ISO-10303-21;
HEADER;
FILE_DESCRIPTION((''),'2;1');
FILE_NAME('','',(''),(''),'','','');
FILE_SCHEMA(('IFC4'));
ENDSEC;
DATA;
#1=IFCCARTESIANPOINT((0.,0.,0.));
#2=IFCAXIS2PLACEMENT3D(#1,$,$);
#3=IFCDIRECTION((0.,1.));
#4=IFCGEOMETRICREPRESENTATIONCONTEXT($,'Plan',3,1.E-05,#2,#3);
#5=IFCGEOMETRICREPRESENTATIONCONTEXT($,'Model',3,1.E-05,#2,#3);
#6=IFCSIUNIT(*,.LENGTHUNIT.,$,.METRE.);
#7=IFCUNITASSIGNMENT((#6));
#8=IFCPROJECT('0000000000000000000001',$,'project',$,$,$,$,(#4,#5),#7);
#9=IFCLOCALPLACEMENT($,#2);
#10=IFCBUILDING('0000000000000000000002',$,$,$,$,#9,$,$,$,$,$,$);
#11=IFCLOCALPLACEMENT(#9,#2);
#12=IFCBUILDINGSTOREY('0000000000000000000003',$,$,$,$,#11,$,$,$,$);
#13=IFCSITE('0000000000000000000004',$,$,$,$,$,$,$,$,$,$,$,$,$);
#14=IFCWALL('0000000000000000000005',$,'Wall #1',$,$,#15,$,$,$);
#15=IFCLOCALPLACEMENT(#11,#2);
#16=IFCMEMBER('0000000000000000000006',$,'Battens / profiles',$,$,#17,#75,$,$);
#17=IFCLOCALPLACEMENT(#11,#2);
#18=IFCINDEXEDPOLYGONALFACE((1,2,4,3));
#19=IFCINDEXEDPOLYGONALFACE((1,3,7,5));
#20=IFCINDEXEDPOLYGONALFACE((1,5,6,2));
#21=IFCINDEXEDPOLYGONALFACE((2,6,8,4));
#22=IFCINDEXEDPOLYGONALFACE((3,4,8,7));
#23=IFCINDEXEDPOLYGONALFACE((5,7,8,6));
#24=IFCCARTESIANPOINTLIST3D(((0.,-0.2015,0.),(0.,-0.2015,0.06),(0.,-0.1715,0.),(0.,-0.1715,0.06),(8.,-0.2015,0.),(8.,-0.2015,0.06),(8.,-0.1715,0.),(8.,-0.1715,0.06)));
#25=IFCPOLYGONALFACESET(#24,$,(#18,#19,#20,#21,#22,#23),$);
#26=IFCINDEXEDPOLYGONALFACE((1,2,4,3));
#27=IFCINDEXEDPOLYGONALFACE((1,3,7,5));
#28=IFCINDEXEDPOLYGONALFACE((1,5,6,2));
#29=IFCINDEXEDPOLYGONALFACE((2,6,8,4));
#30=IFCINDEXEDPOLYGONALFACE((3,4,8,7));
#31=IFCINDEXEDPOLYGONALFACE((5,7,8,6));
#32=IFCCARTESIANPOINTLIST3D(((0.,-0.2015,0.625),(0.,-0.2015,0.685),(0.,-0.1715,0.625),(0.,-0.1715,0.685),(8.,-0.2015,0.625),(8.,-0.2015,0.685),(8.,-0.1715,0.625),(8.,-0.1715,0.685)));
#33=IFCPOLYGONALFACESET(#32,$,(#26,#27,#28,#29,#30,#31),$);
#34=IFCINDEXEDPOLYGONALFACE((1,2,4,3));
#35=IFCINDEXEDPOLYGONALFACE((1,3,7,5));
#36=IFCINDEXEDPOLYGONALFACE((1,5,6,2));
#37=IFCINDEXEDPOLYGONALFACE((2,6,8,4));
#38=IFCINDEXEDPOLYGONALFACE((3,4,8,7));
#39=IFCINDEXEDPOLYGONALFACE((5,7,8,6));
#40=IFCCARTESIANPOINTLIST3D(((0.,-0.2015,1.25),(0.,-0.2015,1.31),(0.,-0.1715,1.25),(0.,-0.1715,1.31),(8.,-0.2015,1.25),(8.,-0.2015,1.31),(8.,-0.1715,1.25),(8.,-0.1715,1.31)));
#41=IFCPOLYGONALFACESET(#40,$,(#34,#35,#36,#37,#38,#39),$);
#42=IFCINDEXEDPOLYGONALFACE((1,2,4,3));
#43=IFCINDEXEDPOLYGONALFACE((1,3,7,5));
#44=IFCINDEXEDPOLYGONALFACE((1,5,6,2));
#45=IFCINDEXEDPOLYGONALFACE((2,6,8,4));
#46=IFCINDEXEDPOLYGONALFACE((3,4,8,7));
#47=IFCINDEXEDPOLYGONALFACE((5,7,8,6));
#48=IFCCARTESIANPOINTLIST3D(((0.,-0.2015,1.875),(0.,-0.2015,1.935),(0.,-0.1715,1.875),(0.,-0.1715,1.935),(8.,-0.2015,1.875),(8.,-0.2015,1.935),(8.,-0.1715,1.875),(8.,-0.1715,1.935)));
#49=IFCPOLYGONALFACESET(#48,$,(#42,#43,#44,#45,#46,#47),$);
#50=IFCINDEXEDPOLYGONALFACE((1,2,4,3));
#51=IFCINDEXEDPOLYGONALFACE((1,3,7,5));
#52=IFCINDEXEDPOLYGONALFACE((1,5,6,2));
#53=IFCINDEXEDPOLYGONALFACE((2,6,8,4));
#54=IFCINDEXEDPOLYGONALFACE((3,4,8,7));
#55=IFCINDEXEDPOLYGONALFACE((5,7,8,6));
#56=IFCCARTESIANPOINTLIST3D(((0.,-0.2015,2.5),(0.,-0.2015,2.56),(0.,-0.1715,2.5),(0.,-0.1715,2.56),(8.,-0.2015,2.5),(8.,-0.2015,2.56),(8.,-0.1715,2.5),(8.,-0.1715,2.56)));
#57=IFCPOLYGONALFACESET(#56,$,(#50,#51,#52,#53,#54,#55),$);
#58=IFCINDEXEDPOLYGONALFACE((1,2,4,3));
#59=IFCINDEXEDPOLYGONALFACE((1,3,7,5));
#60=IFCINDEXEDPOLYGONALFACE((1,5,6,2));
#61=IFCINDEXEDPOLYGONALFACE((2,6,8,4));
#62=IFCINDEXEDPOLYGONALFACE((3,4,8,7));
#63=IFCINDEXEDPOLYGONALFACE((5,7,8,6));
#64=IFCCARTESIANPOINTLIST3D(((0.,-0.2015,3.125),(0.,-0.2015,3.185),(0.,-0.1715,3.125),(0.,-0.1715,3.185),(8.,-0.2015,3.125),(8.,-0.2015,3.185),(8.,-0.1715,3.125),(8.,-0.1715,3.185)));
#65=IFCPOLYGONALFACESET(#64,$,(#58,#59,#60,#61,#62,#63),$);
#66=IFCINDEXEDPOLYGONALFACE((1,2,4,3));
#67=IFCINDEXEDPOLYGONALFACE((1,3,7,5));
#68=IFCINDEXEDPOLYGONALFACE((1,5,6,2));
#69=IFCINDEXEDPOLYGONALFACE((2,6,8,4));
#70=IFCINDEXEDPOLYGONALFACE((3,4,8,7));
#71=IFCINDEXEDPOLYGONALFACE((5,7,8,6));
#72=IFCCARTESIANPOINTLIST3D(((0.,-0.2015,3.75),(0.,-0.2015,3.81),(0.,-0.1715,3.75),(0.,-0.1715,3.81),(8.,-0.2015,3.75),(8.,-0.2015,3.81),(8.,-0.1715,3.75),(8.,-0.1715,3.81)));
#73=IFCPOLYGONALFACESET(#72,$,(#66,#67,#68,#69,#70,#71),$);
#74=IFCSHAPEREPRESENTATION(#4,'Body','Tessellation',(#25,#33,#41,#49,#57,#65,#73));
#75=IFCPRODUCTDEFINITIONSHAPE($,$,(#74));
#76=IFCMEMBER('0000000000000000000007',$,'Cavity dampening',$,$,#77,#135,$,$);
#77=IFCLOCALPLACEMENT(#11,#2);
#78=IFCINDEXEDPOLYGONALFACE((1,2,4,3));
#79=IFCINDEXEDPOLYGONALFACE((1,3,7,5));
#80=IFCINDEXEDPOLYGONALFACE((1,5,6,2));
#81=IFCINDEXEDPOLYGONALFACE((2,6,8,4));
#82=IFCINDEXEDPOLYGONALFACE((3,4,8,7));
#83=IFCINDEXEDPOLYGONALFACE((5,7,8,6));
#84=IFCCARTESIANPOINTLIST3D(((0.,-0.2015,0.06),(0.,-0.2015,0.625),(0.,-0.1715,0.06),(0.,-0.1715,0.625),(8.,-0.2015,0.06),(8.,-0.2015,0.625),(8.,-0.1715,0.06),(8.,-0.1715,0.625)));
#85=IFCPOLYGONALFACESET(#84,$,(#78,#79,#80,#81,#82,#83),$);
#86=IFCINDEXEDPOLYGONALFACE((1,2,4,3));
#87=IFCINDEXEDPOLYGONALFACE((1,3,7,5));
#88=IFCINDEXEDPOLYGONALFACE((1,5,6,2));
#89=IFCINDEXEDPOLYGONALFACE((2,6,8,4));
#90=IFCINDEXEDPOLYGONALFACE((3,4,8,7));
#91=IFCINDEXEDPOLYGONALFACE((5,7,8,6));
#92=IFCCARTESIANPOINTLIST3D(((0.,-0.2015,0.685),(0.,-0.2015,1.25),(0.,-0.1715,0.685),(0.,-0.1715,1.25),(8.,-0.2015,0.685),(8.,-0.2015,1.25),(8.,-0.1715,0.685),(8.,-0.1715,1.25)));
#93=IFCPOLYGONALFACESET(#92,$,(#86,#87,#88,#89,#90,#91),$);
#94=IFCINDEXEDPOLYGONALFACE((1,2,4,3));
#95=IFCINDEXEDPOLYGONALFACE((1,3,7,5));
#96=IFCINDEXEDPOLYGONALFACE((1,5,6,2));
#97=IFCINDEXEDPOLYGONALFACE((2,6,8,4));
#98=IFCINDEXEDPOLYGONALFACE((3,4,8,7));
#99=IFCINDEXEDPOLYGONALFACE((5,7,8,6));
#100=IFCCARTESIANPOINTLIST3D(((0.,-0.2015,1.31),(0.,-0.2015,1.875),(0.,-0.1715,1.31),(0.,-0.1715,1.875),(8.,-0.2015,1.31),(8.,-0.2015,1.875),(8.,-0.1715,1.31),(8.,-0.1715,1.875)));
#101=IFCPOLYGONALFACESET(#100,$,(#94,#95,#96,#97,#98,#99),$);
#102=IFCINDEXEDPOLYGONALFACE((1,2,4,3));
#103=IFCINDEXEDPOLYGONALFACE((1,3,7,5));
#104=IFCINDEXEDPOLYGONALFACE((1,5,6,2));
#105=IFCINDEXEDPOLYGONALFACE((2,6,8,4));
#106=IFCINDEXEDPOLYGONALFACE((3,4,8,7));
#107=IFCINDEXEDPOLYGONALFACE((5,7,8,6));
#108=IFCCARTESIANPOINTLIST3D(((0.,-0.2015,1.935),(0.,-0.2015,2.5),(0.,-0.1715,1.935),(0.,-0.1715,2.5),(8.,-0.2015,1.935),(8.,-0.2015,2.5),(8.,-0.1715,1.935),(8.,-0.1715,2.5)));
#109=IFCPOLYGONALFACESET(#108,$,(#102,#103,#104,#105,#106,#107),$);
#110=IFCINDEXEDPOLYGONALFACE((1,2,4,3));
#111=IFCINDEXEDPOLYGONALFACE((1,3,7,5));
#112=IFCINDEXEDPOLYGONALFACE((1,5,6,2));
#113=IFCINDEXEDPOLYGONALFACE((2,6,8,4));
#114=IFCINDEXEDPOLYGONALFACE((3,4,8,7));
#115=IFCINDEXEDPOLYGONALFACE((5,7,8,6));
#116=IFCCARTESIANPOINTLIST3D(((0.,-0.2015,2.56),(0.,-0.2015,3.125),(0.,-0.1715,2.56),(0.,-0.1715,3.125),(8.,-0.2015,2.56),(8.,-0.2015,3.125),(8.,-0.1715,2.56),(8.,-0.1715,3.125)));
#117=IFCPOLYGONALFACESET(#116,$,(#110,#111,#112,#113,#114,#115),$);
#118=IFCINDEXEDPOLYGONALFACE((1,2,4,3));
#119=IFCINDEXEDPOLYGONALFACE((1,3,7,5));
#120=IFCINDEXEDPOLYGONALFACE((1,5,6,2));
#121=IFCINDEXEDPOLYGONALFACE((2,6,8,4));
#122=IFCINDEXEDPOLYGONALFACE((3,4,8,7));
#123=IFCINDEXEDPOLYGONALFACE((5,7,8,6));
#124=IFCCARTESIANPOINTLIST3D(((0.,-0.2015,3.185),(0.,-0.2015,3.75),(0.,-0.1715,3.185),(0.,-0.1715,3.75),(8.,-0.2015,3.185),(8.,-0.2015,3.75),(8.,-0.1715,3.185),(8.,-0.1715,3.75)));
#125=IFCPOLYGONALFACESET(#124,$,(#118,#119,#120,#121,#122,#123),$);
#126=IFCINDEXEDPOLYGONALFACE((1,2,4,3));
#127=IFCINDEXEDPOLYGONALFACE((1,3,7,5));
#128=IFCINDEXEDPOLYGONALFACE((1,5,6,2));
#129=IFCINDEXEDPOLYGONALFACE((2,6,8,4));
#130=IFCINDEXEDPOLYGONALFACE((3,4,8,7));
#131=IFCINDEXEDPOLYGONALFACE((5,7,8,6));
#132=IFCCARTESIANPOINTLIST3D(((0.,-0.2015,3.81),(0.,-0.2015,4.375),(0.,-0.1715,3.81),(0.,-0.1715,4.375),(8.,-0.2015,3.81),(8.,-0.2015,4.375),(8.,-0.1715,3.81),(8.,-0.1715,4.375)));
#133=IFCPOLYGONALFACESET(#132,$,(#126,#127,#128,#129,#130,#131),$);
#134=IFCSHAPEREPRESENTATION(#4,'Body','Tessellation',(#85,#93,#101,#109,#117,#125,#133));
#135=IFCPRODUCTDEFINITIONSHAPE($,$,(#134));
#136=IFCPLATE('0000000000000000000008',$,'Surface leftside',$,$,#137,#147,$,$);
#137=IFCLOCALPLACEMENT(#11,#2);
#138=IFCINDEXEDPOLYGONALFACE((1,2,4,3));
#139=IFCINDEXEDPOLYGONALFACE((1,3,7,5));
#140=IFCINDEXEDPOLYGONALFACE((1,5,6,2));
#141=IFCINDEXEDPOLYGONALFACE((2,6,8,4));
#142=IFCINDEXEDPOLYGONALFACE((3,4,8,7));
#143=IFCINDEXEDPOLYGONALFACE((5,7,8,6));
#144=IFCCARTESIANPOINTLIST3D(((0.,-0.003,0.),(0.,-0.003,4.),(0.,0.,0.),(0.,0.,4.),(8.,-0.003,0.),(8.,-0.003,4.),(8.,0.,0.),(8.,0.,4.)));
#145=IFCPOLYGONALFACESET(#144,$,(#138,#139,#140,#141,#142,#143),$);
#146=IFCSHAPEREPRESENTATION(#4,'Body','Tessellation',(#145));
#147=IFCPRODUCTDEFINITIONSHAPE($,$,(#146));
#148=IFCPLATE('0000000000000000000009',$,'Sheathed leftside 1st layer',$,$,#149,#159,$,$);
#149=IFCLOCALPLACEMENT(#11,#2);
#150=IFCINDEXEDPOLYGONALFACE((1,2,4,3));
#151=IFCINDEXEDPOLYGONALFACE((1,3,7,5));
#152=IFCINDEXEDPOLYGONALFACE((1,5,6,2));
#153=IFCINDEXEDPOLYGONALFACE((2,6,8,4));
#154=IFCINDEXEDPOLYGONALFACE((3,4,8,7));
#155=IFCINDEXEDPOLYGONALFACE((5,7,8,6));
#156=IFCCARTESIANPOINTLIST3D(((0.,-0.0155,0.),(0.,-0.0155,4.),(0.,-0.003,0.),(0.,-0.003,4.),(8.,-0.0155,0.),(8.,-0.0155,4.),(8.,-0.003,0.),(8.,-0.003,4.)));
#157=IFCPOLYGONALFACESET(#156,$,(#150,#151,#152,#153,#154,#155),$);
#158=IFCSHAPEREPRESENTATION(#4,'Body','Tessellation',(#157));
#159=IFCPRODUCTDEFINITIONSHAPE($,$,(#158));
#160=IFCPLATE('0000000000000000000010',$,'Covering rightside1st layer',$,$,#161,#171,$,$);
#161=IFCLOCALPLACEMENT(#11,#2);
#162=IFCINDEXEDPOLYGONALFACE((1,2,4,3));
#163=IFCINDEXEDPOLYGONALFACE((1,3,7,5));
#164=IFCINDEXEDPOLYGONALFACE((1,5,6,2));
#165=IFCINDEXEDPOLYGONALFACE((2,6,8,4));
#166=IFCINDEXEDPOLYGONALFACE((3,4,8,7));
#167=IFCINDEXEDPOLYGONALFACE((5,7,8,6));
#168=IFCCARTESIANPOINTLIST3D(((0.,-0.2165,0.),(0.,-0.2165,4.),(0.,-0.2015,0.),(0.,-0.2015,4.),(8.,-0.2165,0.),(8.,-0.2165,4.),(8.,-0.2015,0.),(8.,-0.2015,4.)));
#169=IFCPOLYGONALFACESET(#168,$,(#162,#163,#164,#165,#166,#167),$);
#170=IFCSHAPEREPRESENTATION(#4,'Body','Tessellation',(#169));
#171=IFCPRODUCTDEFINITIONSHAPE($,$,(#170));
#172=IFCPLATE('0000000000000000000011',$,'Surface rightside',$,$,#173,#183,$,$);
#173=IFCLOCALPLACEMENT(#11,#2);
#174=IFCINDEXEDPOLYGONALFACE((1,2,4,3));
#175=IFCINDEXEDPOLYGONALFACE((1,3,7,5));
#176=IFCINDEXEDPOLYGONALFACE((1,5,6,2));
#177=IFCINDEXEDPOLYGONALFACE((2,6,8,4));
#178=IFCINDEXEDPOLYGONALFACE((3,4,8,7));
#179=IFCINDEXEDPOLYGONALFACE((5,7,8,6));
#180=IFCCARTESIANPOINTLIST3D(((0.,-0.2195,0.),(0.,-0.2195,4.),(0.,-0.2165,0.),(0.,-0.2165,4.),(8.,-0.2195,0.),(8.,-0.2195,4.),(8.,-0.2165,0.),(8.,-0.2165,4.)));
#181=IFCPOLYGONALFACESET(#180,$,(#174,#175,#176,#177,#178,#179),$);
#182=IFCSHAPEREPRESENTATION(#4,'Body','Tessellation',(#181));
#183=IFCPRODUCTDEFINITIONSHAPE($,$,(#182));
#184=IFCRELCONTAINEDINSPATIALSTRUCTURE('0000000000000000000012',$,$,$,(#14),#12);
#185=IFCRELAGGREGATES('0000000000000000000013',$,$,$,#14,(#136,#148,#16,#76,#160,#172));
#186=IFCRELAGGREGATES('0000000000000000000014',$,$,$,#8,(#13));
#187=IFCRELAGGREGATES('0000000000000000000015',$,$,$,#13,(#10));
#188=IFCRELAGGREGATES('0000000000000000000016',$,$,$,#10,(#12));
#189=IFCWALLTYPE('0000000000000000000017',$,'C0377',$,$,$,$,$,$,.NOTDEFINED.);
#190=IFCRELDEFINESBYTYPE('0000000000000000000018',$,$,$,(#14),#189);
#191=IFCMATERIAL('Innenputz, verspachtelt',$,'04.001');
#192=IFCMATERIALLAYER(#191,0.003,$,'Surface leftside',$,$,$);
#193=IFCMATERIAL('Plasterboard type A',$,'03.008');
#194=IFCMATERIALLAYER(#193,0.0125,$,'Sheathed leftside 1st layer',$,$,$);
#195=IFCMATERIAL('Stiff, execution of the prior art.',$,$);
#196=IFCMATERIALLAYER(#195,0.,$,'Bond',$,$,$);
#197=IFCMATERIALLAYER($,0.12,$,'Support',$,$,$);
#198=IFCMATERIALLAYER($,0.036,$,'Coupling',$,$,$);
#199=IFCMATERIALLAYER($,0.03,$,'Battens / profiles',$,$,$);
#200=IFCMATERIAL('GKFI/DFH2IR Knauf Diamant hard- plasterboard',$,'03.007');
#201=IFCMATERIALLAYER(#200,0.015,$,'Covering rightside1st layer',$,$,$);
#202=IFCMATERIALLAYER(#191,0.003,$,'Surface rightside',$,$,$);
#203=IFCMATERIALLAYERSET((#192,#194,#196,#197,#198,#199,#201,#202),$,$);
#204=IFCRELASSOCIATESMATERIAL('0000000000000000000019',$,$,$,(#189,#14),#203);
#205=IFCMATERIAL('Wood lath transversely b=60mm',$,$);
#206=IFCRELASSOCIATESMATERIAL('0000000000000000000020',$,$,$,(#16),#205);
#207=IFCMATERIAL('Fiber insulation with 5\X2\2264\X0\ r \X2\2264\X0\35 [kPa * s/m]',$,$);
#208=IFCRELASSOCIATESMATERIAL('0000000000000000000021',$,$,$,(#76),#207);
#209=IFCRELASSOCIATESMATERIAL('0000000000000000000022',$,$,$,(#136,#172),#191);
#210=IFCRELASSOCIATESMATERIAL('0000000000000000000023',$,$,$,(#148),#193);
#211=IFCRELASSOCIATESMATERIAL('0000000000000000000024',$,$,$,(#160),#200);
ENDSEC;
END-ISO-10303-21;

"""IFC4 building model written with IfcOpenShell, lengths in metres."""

from ifc_helpers import new_model, si_unit, direction, frame, frame_2d, origin, origin_with_axes, place, context, project, spatial, rectangle, extrude, material, layer, layer_set, type_object, element, aggregate, save


model = new_model("IFC4")

# Units and contexts
plan_context = context("Plan", 3, precision=1e-05, world=origin(), true_north=direction((0.0, 1.0)))
model_context = context("Model", 3, precision=1e-05, world=origin(), true_north=direction((0.0, 1.0)))
ifc_project = project(units=[si_unit("LENGTHUNIT", "METRE")], contexts=[plan_context, model_context])

# Site, building, storey
site = spatial("IfcSite", under=ifc_project)
building_placement = place(None, origin())
building = spatial("IfcBuilding", under=site, at=building_placement)
storey_placement = place(building_placement, origin())
storey = spatial("IfcBuildingStorey", under=building, at=storey_placement)

# Wall, members, plates
ifc_material_1 = material(Name="Innenputz, verspachtelt", Category="04.001")
ifc_layer_1 = layer(ifc_material_1, 0.003, Name="Surface leftside")
ifc_material_2 = material(Name="Plasterboard type A", Category="03.008")
ifc_layer_2 = layer(ifc_material_2, 0.0125, Name="Sheathed leftside 1st layer")
ifc_material_3 = material(Name="Stiff, execution of the prior art.")
ifc_layer_3 = layer(ifc_material_3, 0.0, Name="Bond")
ifc_layer_4 = layer(None, 0.12, Name="Support")
ifc_layer_5 = layer(None, 0.036, Name="Coupling")
ifc_layer_6 = layer(None, 0.03, Name="Battens / profiles")
ifc_material_4 = material(Name="GKFI/DFH2IR Knauf Diamant hard- plasterboard", Category="03.007")
ifc_layer_7 = layer(ifc_material_4, 0.015, Name="Covering rightside1st layer")
ifc_layer_8 = layer(ifc_material_1, 0.003, Name="Surface rightside")
ifc_layer_set = layer_set([ifc_layer_1, ifc_layer_2, ifc_layer_3, ifc_layer_4, ifc_layer_5, ifc_layer_6, ifc_layer_7, ifc_layer_8])
wall_type = type_object("IfcWallType", Name="C0377", PredefinedType="NOTDEFINED", material=ifc_layer_set)
wall_placement = place(None, frame((0.0, 0.0, 0.0), z_axis=(0.0, -1.0, 0.0), x_axis=(1.0, 0.0, 0.0)))
wall = element("IfcWall", 1, at=wall_placement, inside=storey, type_object=wall_type, material=ifc_layer_set, Name="Wall #1")
ifc_material_5 = material(Name="Wood lath transversely b=60mm")
member_1_placement = place(wall_placement, origin())
member_1 = element("IfcMember", 2, at=member_1_placement, material=ifc_material_5, Name="Battens / profiles", context=plan_context, shape_type="SweptSolid", body=[
    extrude(rectangle(XDim=0.06, YDim=0.03, at=frame_2d((0.03, 0.015), x_axis=(1.0, 0.0))), frame((0.0, 0.0, 0.1715), z_axis=(1.0, 0.0, 0.0), x_axis=(0.0, 1.0, 0.0)), (0.0, 0.0, 1.0), 8.0),
    extrude(rectangle(XDim=0.06, YDim=0.03, at=frame_2d((0.03, 0.015), x_axis=(1.0, 0.0))), frame((0.0, 0.625, 0.1715), z_axis=(1.0, 0.0, 0.0), x_axis=(0.0, 1.0, 0.0)), (0.0, 0.0, 1.0), 8.0),
    extrude(rectangle(XDim=0.06, YDim=0.03, at=frame_2d((0.03, 0.015), x_axis=(1.0, 0.0))), frame((0.0, 1.25, 0.1715), z_axis=(1.0, 0.0, 0.0), x_axis=(0.0, 1.0, 0.0)), (0.0, 0.0, 1.0), 8.0),
    extrude(rectangle(XDim=0.06, YDim=0.03, at=frame_2d((0.03, 0.015), x_axis=(1.0, 0.0))), frame((0.0, 1.875, 0.1715), z_axis=(1.0, 0.0, 0.0), x_axis=(0.0, 1.0, 0.0)), (0.0, 0.0, 1.0), 8.0),
    extrude(rectangle(XDim=0.06, YDim=0.03, at=frame_2d((0.03, 0.015), x_axis=(1.0, 0.0))), frame((0.0, 2.5, 0.1715), z_axis=(1.0, 0.0, 0.0), x_axis=(0.0, 1.0, 0.0)), (0.0, 0.0, 1.0), 8.0),
    extrude(rectangle(XDim=0.06, YDim=0.03, at=frame_2d((0.03, 0.015), x_axis=(1.0, 0.0))), frame((0.0, 3.125, 0.1715), z_axis=(1.0, 0.0, 0.0), x_axis=(0.0, 1.0, 0.0)), (0.0, 0.0, 1.0), 8.0),
    extrude(rectangle(XDim=0.06, YDim=0.03, at=frame_2d((0.03, 0.015), x_axis=(1.0, 0.0))), frame((0.0, 3.75, 0.1715), z_axis=(1.0, 0.0, 0.0), x_axis=(0.0, 1.0, 0.0)), (0.0, 0.0, 1.0), 8.0),
])
ifc_material_6 = material(Name="Fiber insulation with 5≤ r ≤35 [kPa * s/m]")
member_2_placement = place(wall_placement, origin())
member_2 = element("IfcMember", 3, at=member_2_placement, material=ifc_material_6, Name="Cavity dampening", context=plan_context, shape_type="SweptSolid", body=[
    extrude(rectangle(XDim=0.565, YDim=0.03, at=frame_2d((0.2825, 0.015), x_axis=(1.0, 0.0))), frame((0.0, 0.06, 0.1715), z_axis=(1.0, 0.0, 0.0), x_axis=(0.0, 1.0, 0.0)), (0.0, 0.0, 1.0), 8.0),
    extrude(rectangle(XDim=0.565, YDim=0.03, at=frame_2d((0.2825, 0.015), x_axis=(1.0, 0.0))), frame((0.0, 0.685, 0.1715), z_axis=(1.0, 0.0, 0.0), x_axis=(0.0, 1.0, 0.0)), (0.0, 0.0, 1.0), 8.0),
    extrude(rectangle(XDim=0.565, YDim=0.03, at=frame_2d((0.2825, 0.015), x_axis=(1.0, 0.0))), frame((0.0, 1.31, 0.1715), z_axis=(1.0, 0.0, 0.0), x_axis=(0.0, 1.0, 0.0)), (0.0, 0.0, 1.0), 8.0),
    extrude(rectangle(XDim=0.565, YDim=0.03, at=frame_2d((0.2825, 0.015), x_axis=(1.0, 0.0))), frame((0.0, 1.935, 0.1715), z_axis=(1.0, 0.0, 0.0), x_axis=(0.0, 1.0, 0.0)), (0.0, 0.0, 1.0), 8.0),
    extrude(rectangle(XDim=0.565, YDim=0.03, at=frame_2d((0.2825, 0.015), x_axis=(1.0, 0.0))), frame((0.0, 2.56, 0.1715), z_axis=(1.0, 0.0, 0.0), x_axis=(0.0, 1.0, 0.0)), (0.0, 0.0, 1.0), 8.0),
    extrude(rectangle(XDim=0.565, YDim=0.03, at=frame_2d((0.2825, 0.015), x_axis=(1.0, 0.0))), frame((0.0, 3.185, 0.1715), z_axis=(1.0, 0.0, 0.0), x_axis=(0.0, 1.0, 0.0)), (0.0, 0.0, 1.0), 8.0),
    extrude(rectangle(XDim=0.565, YDim=0.03, at=frame_2d((0.2825, 0.015), x_axis=(1.0, 0.0))), frame((0.0, 3.81, 0.1715), z_axis=(1.0, 0.0, 0.0), x_axis=(0.0, 1.0, 0.0)), (0.0, 0.0, 1.0), 8.0),
])
plate_1_placement = place(wall_placement, origin())
plate_1 = element("IfcPlate", 4, at=plate_1_placement, material=ifc_material_1, Name="Surface leftside", context=plan_context, shape_type="SweptSolid", body=[
    extrude(rectangle(XDim=8.0, YDim=4.0, at=frame_2d((4.0, 2.0), x_axis=(1.0, 0.0))), origin_with_axes(), (0.0, 0.0, 1.0), 0.003),
])
plate_2_placement = place(wall_placement, origin())
plate_2 = element("IfcPlate", 5, at=plate_2_placement, material=ifc_material_2, Name="Sheathed leftside 1st layer", context=plan_context, shape_type="SweptSolid", body=[
    extrude(rectangle(XDim=8.0, YDim=4.0, at=frame_2d((4.0, 2.0), x_axis=(1.0, 0.0))), frame((0.0, 0.0, 0.003), z_axis=(0.0, 0.0, 1.0), x_axis=(1.0, 0.0, 0.0)), (0.0, 0.0, 1.0), 0.0125),
])
plate_3_placement = place(wall_placement, origin())
plate_3 = element("IfcPlate", 6, at=plate_3_placement, material=ifc_material_4, Name="Covering rightside1st layer", context=plan_context, shape_type="SweptSolid", body=[
    extrude(rectangle(XDim=8.0, YDim=4.0, at=frame_2d((4.0, 2.0), x_axis=(1.0, 0.0))), frame((0.0, 0.0, 0.2015), z_axis=(0.0, 0.0, 1.0), x_axis=(1.0, 0.0, 0.0)), (0.0, 0.0, 1.0), 0.015),
])
plate_4_placement = place(wall_placement, origin())
plate_4 = element("IfcPlate", 7, at=plate_4_placement, material=ifc_material_1, Name="Surface rightside", context=plan_context, shape_type="SweptSolid", body=[
    extrude(rectangle(XDim=8.0, YDim=4.0, at=frame_2d((4.0, 2.0), x_axis=(1.0, 0.0))), frame((0.0, 0.0, 0.2165), z_axis=(0.0, 0.0, 1.0), x_axis=(1.0, 0.0, 0.0)), (0.0, 0.0, 1.0), 0.003),
])
aggregate(wall, [plate_1, plate_2, member_1, member_2, plate_3, plate_4])

save(model, "model.ifc")
